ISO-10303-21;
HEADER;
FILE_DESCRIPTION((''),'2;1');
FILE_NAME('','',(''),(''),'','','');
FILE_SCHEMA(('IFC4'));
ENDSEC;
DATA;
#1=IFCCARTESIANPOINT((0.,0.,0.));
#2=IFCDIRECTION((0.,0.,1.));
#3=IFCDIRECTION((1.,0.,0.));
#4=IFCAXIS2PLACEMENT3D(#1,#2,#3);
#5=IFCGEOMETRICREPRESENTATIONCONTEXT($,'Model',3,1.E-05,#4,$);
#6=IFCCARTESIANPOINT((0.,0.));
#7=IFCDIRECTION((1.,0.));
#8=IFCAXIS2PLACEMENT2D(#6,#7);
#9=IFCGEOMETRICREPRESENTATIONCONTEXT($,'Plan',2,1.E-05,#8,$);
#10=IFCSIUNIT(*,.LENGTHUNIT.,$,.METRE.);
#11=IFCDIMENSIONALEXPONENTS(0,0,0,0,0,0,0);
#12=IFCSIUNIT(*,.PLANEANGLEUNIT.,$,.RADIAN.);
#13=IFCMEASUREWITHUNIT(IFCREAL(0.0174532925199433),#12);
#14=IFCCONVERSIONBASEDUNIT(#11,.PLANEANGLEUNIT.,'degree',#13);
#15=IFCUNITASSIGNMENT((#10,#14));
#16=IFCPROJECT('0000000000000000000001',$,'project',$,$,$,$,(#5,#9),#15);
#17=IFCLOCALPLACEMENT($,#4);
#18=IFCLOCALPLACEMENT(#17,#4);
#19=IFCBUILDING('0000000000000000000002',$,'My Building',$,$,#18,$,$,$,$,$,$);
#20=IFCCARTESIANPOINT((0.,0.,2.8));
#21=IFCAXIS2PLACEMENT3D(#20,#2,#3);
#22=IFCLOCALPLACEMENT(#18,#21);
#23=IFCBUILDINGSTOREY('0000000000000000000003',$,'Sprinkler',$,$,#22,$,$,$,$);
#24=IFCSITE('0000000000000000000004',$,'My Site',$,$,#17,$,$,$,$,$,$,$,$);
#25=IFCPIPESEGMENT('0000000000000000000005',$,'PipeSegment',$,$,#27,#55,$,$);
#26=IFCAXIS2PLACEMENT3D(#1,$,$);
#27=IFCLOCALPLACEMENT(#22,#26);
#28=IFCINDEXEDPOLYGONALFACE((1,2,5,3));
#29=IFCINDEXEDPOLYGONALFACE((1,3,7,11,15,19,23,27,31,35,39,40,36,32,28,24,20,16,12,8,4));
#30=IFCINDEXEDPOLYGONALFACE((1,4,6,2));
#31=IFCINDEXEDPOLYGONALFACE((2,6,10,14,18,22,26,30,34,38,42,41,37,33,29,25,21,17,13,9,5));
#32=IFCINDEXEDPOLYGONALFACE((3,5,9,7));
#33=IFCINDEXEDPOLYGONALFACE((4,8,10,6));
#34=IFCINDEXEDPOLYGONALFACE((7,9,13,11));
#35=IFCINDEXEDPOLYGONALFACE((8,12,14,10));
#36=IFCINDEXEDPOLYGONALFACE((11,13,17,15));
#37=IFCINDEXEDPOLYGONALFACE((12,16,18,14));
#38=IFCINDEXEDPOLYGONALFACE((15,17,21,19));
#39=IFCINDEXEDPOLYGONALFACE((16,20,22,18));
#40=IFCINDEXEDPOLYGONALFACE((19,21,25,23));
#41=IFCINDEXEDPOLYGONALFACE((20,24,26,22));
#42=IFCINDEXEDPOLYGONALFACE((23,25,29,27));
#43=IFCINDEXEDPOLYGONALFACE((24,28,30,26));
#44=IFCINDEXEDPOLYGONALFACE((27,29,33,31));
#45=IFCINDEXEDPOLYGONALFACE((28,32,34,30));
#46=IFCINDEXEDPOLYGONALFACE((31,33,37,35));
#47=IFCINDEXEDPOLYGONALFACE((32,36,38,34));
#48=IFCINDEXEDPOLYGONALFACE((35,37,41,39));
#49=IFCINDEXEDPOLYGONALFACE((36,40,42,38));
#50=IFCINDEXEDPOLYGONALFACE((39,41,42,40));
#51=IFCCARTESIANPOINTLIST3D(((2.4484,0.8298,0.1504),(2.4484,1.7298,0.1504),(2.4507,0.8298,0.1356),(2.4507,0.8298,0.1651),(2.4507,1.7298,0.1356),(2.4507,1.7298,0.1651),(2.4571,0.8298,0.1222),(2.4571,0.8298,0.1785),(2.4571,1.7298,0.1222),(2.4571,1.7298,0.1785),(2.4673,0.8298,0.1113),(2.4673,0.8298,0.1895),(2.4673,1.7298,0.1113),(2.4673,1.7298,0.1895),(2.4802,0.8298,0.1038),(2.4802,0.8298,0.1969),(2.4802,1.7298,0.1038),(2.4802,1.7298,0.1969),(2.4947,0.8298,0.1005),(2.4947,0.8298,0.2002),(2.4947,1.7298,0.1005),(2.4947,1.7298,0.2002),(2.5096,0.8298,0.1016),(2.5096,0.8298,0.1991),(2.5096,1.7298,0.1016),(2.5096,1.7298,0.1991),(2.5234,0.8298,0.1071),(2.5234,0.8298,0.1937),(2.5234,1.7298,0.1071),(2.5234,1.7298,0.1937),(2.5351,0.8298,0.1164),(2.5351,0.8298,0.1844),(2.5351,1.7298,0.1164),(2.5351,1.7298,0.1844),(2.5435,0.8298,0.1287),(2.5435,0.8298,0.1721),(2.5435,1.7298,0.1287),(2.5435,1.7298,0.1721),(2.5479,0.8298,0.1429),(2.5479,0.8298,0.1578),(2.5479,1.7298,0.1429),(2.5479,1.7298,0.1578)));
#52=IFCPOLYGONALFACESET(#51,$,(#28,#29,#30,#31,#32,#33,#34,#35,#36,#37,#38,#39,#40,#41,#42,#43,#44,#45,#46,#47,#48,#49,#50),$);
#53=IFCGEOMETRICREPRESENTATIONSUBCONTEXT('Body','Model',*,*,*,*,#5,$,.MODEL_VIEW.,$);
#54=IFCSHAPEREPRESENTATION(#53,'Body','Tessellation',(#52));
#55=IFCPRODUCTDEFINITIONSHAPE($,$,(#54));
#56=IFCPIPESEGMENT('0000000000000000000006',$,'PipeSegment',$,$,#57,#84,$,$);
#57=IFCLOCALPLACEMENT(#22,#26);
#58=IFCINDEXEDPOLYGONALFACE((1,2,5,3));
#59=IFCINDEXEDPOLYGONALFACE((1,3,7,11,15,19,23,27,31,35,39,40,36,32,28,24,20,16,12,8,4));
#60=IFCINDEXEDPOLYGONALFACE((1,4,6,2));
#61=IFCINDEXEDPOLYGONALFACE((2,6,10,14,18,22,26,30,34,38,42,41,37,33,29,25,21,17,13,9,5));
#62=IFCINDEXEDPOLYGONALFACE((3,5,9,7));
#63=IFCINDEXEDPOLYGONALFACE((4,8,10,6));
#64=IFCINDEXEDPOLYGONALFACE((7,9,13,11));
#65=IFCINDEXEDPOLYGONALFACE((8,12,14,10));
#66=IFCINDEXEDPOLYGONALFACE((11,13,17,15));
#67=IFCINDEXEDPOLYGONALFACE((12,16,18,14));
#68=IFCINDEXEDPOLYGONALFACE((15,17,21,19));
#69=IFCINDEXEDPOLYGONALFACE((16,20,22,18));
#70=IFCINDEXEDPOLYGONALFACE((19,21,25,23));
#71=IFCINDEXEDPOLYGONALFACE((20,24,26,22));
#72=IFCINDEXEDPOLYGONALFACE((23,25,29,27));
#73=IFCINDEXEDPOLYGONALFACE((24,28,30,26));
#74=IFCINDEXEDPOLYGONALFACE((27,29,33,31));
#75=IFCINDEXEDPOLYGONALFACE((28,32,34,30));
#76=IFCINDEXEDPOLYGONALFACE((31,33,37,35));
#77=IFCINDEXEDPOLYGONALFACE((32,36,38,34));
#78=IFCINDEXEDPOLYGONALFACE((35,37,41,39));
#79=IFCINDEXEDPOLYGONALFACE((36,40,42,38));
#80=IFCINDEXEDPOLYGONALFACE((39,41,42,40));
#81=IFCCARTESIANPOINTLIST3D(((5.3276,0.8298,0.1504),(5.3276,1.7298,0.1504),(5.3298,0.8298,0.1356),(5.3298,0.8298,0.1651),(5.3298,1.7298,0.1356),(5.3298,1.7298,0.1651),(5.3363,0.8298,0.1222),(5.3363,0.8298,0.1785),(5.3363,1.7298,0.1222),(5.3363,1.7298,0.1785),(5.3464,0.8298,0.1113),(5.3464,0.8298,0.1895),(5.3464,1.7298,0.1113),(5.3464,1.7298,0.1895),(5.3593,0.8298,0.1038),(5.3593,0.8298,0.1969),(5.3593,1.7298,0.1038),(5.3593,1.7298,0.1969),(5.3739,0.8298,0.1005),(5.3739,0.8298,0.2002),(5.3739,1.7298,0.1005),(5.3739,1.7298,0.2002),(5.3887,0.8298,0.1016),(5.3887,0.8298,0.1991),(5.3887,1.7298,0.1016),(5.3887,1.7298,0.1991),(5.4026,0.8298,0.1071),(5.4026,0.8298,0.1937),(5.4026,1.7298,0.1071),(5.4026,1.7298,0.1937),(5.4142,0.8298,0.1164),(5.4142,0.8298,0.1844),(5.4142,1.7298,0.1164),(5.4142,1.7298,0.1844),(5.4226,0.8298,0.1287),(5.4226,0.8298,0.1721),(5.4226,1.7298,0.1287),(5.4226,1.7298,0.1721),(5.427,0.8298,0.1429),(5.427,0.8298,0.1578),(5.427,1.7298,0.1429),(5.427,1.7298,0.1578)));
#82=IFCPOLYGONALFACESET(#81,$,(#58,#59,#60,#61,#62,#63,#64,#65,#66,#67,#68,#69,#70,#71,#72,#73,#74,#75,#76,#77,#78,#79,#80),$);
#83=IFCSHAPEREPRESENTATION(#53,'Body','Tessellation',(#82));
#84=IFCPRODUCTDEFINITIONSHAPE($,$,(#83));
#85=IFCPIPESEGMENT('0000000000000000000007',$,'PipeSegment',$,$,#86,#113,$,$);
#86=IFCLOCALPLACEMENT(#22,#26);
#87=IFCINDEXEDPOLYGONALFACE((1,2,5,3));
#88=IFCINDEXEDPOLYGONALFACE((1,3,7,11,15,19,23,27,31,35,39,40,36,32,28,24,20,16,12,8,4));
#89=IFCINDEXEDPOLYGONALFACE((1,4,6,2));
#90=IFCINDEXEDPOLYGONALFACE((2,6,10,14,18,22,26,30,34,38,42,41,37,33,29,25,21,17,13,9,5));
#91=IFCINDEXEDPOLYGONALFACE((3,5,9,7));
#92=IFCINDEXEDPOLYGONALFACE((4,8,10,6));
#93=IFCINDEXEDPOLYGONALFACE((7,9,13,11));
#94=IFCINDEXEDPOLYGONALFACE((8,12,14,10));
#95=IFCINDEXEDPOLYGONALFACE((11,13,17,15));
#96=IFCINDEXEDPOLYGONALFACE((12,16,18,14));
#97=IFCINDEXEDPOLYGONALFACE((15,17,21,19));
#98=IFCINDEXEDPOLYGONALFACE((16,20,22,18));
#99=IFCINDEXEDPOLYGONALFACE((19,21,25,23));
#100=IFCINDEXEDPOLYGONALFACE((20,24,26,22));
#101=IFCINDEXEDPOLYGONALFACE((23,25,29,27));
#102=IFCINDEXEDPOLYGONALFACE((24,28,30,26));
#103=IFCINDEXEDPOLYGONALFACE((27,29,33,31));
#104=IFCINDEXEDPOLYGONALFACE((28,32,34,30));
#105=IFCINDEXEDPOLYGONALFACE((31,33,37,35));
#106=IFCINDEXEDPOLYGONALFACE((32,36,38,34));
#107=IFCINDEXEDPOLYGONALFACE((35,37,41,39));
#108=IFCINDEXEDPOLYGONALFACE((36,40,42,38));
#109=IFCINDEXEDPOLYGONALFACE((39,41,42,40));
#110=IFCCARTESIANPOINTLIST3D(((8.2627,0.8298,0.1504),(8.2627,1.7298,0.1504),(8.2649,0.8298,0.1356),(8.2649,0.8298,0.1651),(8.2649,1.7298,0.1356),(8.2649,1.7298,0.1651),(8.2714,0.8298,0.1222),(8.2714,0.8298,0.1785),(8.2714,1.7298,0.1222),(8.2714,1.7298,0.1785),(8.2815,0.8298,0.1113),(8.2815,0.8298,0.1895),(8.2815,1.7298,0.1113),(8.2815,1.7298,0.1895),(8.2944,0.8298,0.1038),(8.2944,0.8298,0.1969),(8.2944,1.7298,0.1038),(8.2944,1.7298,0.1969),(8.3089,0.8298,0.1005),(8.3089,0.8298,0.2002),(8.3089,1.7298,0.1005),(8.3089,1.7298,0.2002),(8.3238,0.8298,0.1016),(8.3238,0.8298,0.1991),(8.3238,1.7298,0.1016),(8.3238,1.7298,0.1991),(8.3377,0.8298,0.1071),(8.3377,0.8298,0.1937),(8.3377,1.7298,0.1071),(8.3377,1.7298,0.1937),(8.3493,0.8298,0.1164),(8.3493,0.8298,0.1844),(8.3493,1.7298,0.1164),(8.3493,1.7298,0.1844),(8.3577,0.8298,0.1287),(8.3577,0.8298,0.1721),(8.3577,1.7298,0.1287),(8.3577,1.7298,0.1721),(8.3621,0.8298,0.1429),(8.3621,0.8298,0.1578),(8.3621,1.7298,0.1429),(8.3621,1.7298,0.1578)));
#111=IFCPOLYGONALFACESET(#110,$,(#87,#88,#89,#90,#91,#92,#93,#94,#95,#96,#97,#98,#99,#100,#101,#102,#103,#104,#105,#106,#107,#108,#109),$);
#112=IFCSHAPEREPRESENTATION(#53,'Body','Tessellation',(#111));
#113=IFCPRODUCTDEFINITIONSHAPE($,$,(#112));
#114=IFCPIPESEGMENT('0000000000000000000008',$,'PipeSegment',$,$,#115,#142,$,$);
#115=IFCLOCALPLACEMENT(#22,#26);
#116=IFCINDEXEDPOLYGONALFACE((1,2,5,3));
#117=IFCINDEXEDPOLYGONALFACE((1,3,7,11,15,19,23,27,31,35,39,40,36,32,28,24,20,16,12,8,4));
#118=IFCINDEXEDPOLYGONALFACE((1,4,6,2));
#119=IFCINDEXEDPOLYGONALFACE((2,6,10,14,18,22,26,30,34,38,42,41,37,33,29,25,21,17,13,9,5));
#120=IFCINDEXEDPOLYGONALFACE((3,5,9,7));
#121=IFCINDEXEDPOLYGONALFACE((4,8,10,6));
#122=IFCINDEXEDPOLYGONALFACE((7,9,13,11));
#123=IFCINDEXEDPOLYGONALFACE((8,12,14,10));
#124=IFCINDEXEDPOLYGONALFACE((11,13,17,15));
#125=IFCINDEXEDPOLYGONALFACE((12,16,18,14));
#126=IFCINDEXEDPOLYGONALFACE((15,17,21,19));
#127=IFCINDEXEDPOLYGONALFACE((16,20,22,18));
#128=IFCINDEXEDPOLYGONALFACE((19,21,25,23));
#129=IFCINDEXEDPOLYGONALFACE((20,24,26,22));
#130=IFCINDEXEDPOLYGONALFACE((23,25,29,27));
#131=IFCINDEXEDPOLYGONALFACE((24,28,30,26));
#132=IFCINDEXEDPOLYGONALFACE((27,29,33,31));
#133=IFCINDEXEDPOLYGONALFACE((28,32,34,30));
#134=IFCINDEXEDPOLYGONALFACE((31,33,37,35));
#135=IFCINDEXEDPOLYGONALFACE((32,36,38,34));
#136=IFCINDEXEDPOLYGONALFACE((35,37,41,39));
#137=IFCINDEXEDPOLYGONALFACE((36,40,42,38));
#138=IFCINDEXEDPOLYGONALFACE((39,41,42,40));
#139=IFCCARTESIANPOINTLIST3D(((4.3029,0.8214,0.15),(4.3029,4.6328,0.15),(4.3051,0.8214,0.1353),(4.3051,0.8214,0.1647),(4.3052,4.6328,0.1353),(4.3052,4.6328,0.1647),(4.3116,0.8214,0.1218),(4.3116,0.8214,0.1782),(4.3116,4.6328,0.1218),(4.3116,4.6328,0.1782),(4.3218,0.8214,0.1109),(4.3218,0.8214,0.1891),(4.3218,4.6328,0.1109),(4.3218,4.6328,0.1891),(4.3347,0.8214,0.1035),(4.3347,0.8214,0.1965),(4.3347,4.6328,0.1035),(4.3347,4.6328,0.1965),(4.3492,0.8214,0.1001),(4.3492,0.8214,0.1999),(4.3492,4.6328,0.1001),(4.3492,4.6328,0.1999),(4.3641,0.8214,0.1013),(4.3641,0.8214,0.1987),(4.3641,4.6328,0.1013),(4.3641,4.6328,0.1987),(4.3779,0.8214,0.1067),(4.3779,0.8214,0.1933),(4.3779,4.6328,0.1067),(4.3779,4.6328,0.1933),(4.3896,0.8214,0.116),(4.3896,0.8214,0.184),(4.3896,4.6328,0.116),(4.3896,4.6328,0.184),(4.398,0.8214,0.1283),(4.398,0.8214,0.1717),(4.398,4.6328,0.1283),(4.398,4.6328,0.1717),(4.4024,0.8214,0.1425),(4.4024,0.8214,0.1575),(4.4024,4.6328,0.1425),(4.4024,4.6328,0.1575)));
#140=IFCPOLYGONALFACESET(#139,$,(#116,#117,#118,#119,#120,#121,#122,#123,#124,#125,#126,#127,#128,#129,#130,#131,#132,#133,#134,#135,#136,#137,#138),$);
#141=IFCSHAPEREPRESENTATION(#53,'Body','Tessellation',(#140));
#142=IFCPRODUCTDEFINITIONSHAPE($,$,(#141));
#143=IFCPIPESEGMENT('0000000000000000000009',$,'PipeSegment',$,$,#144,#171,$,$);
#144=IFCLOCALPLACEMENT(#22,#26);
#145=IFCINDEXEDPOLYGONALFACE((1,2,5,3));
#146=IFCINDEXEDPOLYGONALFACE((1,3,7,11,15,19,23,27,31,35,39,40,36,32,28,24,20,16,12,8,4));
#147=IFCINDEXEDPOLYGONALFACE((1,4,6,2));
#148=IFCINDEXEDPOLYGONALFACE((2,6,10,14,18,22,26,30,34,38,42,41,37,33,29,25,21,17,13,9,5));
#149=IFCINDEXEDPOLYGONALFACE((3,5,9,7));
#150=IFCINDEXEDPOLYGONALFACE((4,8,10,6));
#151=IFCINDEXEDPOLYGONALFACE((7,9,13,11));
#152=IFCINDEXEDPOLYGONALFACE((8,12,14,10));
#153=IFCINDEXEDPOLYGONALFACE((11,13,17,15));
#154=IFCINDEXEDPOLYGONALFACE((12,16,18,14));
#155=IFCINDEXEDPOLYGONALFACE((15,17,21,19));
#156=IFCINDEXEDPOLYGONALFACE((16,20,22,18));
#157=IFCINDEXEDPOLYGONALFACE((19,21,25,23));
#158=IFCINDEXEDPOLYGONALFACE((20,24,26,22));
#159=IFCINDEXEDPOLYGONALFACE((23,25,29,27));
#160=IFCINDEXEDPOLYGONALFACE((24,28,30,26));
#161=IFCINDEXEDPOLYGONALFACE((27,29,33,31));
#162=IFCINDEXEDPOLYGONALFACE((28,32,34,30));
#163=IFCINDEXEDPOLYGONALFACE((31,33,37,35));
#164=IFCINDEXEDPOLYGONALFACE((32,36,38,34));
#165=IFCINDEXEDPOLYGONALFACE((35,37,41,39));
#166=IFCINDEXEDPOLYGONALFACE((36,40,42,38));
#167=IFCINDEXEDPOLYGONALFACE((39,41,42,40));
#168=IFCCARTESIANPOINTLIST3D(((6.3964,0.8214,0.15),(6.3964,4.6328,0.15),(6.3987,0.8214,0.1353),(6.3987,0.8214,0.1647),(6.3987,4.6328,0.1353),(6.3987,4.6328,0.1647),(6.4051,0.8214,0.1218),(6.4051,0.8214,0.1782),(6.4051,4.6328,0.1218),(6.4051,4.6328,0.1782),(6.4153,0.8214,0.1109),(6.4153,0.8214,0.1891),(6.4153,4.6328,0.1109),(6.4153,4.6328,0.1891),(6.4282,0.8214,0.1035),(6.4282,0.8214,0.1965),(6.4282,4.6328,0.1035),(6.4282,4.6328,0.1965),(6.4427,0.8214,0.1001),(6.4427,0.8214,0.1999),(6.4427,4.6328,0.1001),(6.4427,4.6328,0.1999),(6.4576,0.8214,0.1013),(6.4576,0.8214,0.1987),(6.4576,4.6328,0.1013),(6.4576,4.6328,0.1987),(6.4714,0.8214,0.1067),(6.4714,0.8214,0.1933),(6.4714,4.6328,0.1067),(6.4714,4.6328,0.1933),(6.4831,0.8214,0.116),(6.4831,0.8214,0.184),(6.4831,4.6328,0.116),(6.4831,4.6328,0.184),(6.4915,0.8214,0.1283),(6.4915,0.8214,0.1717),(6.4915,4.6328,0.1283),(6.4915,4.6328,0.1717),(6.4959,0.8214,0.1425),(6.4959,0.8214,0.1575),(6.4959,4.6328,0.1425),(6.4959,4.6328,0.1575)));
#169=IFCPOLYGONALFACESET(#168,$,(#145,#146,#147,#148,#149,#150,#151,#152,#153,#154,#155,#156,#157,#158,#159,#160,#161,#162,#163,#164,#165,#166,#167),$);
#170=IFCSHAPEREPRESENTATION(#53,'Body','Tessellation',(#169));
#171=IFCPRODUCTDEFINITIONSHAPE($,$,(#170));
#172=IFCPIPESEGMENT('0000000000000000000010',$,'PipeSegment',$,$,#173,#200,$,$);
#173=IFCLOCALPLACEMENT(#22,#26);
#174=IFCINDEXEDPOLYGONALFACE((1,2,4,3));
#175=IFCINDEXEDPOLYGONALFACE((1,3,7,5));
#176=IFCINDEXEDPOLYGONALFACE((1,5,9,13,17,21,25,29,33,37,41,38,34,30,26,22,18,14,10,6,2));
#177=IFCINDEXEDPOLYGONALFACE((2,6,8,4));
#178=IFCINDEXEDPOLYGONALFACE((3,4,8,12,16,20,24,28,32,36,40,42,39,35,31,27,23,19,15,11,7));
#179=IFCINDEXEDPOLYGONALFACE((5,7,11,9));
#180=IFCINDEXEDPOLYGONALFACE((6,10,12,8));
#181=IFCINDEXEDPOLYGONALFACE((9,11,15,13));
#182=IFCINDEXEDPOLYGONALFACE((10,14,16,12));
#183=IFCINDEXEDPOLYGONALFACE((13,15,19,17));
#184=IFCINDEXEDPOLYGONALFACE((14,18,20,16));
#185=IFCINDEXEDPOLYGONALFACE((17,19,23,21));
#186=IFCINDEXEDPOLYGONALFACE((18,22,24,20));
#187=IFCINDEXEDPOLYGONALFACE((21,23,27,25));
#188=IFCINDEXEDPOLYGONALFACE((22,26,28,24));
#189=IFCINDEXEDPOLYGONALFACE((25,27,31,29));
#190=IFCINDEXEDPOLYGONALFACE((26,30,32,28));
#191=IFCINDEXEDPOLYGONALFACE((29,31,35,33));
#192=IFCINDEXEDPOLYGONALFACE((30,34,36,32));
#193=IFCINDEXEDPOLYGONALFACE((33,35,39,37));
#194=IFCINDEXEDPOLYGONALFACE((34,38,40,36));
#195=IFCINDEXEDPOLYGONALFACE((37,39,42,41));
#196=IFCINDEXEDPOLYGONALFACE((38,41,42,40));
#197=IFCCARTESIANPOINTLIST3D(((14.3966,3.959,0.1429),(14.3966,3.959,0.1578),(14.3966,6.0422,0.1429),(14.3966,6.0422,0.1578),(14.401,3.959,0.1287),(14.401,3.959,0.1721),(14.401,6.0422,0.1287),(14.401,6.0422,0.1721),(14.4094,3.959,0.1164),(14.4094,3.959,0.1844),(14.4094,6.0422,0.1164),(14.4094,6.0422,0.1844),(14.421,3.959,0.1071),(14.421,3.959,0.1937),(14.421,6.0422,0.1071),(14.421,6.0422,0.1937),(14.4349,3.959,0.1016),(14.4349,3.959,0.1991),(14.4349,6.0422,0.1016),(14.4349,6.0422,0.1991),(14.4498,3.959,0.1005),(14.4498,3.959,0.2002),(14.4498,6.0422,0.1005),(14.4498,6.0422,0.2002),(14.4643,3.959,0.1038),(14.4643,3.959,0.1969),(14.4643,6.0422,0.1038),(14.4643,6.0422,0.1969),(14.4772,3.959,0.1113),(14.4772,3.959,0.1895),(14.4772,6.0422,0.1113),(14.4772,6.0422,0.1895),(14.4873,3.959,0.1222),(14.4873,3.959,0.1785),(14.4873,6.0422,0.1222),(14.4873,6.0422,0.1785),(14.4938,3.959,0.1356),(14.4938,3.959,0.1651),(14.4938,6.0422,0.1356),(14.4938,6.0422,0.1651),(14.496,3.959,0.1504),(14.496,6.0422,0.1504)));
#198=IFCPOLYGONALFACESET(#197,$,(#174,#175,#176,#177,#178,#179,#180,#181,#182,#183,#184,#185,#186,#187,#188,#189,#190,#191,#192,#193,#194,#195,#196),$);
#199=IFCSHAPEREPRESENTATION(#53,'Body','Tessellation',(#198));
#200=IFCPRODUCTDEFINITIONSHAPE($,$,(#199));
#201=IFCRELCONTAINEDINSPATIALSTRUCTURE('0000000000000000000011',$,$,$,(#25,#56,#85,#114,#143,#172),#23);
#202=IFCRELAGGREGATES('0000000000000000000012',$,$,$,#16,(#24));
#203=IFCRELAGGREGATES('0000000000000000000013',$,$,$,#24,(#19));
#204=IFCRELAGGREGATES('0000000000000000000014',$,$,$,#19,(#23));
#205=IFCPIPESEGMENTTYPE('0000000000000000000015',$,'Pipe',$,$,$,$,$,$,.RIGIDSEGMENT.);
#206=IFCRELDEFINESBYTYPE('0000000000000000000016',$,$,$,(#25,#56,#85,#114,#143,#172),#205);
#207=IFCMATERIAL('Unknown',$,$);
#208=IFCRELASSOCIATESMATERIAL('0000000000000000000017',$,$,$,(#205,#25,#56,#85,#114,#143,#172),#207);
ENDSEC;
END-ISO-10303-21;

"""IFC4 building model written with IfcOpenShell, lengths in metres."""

from ifc_helpers import new_model, entity, si_unit, converted_unit, frame, origin_with_axes, origin_2d_with_axis, place, context, subcontext, project, spatial, circle, extrude, material, material_profile, profile_set, profile_usage, type_object, element, save


model = new_model("IFC4")

# Units and contexts
model_context = context("Model", 3, precision=1e-05, world=origin_with_axes())
plan_context = context("Plan", 2, precision=1e-05, world=origin_2d_with_axis())
body_context = subcontext(model_context, "Body", "Model", "MODEL_VIEW")
ifc_project = project(units=[si_unit("LENGTHUNIT", "METRE"), converted_unit("PLANEANGLEUNIT", "degree", entity("IfcReal", 0.0174532925199433), si_unit("PLANEANGLEUNIT", "RADIAN"), dimensions=[0, 0, 0, 0, 0, 0, 0])], contexts=[model_context, plan_context])

# Site, building, storey
site_placement = place(None, origin_with_axes())
site = spatial("IfcSite", under=ifc_project, at=site_placement, Name="My Site")
building_placement = place(site_placement, origin_with_axes())
building = spatial("IfcBuilding", under=site, at=building_placement, Name="My Building")
storey_placement = place(building_placement, frame((0.0, 0.0, 2.8), z_axis=(0.0, 0.0, 1.0), x_axis=(1.0, 0.0, 0.0)))
storey = spatial("IfcBuildingStorey", under=building, at=storey_placement, Name="Sprinkler")

# Pipe segments
ifc_material = material(Name="Unknown")
ifc_material_profile_1 = material_profile(ifc_material, circle(Radius=0.05))
ifc_profile_set_1 = profile_set([ifc_material_profile_1])
pipe_segment_type = type_object("IfcPipeSegmentType", Name="Pipe", PredefinedType="RIGIDSEGMENT", material=ifc_profile_set_1)
ifc_profile_usage_1 = profile_usage(ifc_profile_set_1, cardinal=8)
pipe_segment_1_placement = place(storey_placement, frame((2.4984, 0.8298, 0.2004), z_axis=(0.0, 1.0, 0.0), x_axis=(-1.0, 0.0, 0.0)))
element("IfcPipeSegment", 1, at=pipe_segment_1_placement, inside=storey, type_object=pipe_segment_type, material=ifc_profile_usage_1, Name="PipeSegment", context=body_context, shape_type="SweptSolid", body=[
    extrude(circle(Radius=0.05), frame((0.0, -0.05, 0.0), z_axis=(0.0, 0.0, 1.0), x_axis=(1.0, 0.0, 0.0)), (0.0, 0.0, 1.0), 0.9),
])
ifc_profile_usage_2 = profile_usage(ifc_profile_set_1, cardinal=8)
pipe_segment_2_placement = place(storey_placement, frame((5.3776, 0.8298, 0.2004), z_axis=(0.0, 1.0, 0.0), x_axis=(-1.0, 0.0, 0.0)))
element("IfcPipeSegment", 2, at=pipe_segment_2_placement, inside=storey, type_object=pipe_segment_type, material=ifc_profile_usage_2, Name="PipeSegment", context=body_context, shape_type="SweptSolid", body=[
    extrude(circle(Radius=0.05), frame((0.0, -0.05, 0.0), z_axis=(0.0, 0.0, 1.0), x_axis=(1.0, 0.0, 0.0)), (0.0, 0.0, 1.0), 0.9),
])
ifc_profile_usage_3 = profile_usage(ifc_profile_set_1, cardinal=8)
pipe_segment_3_placement = place(storey_placement, frame((8.3127, 0.8298, 0.2004), z_axis=(0.0, 1.0, 0.0), x_axis=(-1.0, 0.0, 0.0)))
element("IfcPipeSegment", 3, at=pipe_segment_3_placement, inside=storey, type_object=pipe_segment_type, material=ifc_profile_usage_3, Name="PipeSegment", context=body_context, shape_type="SweptSolid", body=[
    extrude(circle(Radius=0.05), frame((0.0, -0.05, 0.0), z_axis=(0.0, 0.0, 1.0), x_axis=(1.0, 0.0, 0.0)), (0.0, 0.0, 1.0), 0.9),
])
ifc_profile_usage_4 = profile_usage(ifc_profile_set_1, cardinal=8)
pipe_segment_4_placement = place(storey_placement, frame((4.3529, 0.8214, 0.2), z_axis=(0.0, 1.0, 0.0), x_axis=(-1.0, 0.0, 0.0)))
element("IfcPipeSegment", 4, at=pipe_segment_4_placement, inside=storey, type_object=pipe_segment_type, material=ifc_profile_usage_4, Name="PipeSegment", context=body_context, shape_type="SweptSolid", body=[
    extrude(circle(Radius=0.05), frame((0.0, -0.05, 0.0), z_axis=(0.0, 0.0, 1.0), x_axis=(1.0, 0.0, 0.0)), (0.0, 0.0, 1.0), 3.8114),
])
ifc_profile_usage_5 = profile_usage(ifc_profile_set_1, cardinal=8)
pipe_segment_5_placement = place(storey_placement, frame((6.4464, 0.8214, 0.2), z_axis=(0.0, 1.0, 0.0), x_axis=(-1.0, 0.0, 0.0)))
element("IfcPipeSegment", 5, at=pipe_segment_5_placement, inside=storey, type_object=pipe_segment_type, material=ifc_profile_usage_5, Name="PipeSegment", context=body_context, shape_type="SweptSolid", body=[
    extrude(circle(Radius=0.05), frame((0.0, -0.05, 0.0), z_axis=(0.0, 0.0, 1.0), x_axis=(1.0, 0.0, 0.0)), (0.0, 0.0, 1.0), 3.8114),
])
ifc_profile_usage_6 = profile_usage(ifc_profile_set_1, cardinal=8)
pipe_segment_6_placement = place(storey_placement, frame((14.446, 6.0422, 0.2004), z_axis=(0.0, -1.0, 0.0), x_axis=(1.0, 0.0, 0.0)))
element("IfcPipeSegment", 6, at=pipe_segment_6_placement, inside=storey, type_object=pipe_segment_type, material=ifc_profile_usage_6, Name="PipeSegment", context=body_context, shape_type="SweptSolid", body=[
    extrude(circle(Radius=0.05), frame((0.0, -0.05, 0.0), z_axis=(0.0, 0.0, 1.0), x_axis=(1.0, 0.0, 0.0)), (0.0, 0.0, 1.0), 2.0832),
])

save(model, "model.ifc")
